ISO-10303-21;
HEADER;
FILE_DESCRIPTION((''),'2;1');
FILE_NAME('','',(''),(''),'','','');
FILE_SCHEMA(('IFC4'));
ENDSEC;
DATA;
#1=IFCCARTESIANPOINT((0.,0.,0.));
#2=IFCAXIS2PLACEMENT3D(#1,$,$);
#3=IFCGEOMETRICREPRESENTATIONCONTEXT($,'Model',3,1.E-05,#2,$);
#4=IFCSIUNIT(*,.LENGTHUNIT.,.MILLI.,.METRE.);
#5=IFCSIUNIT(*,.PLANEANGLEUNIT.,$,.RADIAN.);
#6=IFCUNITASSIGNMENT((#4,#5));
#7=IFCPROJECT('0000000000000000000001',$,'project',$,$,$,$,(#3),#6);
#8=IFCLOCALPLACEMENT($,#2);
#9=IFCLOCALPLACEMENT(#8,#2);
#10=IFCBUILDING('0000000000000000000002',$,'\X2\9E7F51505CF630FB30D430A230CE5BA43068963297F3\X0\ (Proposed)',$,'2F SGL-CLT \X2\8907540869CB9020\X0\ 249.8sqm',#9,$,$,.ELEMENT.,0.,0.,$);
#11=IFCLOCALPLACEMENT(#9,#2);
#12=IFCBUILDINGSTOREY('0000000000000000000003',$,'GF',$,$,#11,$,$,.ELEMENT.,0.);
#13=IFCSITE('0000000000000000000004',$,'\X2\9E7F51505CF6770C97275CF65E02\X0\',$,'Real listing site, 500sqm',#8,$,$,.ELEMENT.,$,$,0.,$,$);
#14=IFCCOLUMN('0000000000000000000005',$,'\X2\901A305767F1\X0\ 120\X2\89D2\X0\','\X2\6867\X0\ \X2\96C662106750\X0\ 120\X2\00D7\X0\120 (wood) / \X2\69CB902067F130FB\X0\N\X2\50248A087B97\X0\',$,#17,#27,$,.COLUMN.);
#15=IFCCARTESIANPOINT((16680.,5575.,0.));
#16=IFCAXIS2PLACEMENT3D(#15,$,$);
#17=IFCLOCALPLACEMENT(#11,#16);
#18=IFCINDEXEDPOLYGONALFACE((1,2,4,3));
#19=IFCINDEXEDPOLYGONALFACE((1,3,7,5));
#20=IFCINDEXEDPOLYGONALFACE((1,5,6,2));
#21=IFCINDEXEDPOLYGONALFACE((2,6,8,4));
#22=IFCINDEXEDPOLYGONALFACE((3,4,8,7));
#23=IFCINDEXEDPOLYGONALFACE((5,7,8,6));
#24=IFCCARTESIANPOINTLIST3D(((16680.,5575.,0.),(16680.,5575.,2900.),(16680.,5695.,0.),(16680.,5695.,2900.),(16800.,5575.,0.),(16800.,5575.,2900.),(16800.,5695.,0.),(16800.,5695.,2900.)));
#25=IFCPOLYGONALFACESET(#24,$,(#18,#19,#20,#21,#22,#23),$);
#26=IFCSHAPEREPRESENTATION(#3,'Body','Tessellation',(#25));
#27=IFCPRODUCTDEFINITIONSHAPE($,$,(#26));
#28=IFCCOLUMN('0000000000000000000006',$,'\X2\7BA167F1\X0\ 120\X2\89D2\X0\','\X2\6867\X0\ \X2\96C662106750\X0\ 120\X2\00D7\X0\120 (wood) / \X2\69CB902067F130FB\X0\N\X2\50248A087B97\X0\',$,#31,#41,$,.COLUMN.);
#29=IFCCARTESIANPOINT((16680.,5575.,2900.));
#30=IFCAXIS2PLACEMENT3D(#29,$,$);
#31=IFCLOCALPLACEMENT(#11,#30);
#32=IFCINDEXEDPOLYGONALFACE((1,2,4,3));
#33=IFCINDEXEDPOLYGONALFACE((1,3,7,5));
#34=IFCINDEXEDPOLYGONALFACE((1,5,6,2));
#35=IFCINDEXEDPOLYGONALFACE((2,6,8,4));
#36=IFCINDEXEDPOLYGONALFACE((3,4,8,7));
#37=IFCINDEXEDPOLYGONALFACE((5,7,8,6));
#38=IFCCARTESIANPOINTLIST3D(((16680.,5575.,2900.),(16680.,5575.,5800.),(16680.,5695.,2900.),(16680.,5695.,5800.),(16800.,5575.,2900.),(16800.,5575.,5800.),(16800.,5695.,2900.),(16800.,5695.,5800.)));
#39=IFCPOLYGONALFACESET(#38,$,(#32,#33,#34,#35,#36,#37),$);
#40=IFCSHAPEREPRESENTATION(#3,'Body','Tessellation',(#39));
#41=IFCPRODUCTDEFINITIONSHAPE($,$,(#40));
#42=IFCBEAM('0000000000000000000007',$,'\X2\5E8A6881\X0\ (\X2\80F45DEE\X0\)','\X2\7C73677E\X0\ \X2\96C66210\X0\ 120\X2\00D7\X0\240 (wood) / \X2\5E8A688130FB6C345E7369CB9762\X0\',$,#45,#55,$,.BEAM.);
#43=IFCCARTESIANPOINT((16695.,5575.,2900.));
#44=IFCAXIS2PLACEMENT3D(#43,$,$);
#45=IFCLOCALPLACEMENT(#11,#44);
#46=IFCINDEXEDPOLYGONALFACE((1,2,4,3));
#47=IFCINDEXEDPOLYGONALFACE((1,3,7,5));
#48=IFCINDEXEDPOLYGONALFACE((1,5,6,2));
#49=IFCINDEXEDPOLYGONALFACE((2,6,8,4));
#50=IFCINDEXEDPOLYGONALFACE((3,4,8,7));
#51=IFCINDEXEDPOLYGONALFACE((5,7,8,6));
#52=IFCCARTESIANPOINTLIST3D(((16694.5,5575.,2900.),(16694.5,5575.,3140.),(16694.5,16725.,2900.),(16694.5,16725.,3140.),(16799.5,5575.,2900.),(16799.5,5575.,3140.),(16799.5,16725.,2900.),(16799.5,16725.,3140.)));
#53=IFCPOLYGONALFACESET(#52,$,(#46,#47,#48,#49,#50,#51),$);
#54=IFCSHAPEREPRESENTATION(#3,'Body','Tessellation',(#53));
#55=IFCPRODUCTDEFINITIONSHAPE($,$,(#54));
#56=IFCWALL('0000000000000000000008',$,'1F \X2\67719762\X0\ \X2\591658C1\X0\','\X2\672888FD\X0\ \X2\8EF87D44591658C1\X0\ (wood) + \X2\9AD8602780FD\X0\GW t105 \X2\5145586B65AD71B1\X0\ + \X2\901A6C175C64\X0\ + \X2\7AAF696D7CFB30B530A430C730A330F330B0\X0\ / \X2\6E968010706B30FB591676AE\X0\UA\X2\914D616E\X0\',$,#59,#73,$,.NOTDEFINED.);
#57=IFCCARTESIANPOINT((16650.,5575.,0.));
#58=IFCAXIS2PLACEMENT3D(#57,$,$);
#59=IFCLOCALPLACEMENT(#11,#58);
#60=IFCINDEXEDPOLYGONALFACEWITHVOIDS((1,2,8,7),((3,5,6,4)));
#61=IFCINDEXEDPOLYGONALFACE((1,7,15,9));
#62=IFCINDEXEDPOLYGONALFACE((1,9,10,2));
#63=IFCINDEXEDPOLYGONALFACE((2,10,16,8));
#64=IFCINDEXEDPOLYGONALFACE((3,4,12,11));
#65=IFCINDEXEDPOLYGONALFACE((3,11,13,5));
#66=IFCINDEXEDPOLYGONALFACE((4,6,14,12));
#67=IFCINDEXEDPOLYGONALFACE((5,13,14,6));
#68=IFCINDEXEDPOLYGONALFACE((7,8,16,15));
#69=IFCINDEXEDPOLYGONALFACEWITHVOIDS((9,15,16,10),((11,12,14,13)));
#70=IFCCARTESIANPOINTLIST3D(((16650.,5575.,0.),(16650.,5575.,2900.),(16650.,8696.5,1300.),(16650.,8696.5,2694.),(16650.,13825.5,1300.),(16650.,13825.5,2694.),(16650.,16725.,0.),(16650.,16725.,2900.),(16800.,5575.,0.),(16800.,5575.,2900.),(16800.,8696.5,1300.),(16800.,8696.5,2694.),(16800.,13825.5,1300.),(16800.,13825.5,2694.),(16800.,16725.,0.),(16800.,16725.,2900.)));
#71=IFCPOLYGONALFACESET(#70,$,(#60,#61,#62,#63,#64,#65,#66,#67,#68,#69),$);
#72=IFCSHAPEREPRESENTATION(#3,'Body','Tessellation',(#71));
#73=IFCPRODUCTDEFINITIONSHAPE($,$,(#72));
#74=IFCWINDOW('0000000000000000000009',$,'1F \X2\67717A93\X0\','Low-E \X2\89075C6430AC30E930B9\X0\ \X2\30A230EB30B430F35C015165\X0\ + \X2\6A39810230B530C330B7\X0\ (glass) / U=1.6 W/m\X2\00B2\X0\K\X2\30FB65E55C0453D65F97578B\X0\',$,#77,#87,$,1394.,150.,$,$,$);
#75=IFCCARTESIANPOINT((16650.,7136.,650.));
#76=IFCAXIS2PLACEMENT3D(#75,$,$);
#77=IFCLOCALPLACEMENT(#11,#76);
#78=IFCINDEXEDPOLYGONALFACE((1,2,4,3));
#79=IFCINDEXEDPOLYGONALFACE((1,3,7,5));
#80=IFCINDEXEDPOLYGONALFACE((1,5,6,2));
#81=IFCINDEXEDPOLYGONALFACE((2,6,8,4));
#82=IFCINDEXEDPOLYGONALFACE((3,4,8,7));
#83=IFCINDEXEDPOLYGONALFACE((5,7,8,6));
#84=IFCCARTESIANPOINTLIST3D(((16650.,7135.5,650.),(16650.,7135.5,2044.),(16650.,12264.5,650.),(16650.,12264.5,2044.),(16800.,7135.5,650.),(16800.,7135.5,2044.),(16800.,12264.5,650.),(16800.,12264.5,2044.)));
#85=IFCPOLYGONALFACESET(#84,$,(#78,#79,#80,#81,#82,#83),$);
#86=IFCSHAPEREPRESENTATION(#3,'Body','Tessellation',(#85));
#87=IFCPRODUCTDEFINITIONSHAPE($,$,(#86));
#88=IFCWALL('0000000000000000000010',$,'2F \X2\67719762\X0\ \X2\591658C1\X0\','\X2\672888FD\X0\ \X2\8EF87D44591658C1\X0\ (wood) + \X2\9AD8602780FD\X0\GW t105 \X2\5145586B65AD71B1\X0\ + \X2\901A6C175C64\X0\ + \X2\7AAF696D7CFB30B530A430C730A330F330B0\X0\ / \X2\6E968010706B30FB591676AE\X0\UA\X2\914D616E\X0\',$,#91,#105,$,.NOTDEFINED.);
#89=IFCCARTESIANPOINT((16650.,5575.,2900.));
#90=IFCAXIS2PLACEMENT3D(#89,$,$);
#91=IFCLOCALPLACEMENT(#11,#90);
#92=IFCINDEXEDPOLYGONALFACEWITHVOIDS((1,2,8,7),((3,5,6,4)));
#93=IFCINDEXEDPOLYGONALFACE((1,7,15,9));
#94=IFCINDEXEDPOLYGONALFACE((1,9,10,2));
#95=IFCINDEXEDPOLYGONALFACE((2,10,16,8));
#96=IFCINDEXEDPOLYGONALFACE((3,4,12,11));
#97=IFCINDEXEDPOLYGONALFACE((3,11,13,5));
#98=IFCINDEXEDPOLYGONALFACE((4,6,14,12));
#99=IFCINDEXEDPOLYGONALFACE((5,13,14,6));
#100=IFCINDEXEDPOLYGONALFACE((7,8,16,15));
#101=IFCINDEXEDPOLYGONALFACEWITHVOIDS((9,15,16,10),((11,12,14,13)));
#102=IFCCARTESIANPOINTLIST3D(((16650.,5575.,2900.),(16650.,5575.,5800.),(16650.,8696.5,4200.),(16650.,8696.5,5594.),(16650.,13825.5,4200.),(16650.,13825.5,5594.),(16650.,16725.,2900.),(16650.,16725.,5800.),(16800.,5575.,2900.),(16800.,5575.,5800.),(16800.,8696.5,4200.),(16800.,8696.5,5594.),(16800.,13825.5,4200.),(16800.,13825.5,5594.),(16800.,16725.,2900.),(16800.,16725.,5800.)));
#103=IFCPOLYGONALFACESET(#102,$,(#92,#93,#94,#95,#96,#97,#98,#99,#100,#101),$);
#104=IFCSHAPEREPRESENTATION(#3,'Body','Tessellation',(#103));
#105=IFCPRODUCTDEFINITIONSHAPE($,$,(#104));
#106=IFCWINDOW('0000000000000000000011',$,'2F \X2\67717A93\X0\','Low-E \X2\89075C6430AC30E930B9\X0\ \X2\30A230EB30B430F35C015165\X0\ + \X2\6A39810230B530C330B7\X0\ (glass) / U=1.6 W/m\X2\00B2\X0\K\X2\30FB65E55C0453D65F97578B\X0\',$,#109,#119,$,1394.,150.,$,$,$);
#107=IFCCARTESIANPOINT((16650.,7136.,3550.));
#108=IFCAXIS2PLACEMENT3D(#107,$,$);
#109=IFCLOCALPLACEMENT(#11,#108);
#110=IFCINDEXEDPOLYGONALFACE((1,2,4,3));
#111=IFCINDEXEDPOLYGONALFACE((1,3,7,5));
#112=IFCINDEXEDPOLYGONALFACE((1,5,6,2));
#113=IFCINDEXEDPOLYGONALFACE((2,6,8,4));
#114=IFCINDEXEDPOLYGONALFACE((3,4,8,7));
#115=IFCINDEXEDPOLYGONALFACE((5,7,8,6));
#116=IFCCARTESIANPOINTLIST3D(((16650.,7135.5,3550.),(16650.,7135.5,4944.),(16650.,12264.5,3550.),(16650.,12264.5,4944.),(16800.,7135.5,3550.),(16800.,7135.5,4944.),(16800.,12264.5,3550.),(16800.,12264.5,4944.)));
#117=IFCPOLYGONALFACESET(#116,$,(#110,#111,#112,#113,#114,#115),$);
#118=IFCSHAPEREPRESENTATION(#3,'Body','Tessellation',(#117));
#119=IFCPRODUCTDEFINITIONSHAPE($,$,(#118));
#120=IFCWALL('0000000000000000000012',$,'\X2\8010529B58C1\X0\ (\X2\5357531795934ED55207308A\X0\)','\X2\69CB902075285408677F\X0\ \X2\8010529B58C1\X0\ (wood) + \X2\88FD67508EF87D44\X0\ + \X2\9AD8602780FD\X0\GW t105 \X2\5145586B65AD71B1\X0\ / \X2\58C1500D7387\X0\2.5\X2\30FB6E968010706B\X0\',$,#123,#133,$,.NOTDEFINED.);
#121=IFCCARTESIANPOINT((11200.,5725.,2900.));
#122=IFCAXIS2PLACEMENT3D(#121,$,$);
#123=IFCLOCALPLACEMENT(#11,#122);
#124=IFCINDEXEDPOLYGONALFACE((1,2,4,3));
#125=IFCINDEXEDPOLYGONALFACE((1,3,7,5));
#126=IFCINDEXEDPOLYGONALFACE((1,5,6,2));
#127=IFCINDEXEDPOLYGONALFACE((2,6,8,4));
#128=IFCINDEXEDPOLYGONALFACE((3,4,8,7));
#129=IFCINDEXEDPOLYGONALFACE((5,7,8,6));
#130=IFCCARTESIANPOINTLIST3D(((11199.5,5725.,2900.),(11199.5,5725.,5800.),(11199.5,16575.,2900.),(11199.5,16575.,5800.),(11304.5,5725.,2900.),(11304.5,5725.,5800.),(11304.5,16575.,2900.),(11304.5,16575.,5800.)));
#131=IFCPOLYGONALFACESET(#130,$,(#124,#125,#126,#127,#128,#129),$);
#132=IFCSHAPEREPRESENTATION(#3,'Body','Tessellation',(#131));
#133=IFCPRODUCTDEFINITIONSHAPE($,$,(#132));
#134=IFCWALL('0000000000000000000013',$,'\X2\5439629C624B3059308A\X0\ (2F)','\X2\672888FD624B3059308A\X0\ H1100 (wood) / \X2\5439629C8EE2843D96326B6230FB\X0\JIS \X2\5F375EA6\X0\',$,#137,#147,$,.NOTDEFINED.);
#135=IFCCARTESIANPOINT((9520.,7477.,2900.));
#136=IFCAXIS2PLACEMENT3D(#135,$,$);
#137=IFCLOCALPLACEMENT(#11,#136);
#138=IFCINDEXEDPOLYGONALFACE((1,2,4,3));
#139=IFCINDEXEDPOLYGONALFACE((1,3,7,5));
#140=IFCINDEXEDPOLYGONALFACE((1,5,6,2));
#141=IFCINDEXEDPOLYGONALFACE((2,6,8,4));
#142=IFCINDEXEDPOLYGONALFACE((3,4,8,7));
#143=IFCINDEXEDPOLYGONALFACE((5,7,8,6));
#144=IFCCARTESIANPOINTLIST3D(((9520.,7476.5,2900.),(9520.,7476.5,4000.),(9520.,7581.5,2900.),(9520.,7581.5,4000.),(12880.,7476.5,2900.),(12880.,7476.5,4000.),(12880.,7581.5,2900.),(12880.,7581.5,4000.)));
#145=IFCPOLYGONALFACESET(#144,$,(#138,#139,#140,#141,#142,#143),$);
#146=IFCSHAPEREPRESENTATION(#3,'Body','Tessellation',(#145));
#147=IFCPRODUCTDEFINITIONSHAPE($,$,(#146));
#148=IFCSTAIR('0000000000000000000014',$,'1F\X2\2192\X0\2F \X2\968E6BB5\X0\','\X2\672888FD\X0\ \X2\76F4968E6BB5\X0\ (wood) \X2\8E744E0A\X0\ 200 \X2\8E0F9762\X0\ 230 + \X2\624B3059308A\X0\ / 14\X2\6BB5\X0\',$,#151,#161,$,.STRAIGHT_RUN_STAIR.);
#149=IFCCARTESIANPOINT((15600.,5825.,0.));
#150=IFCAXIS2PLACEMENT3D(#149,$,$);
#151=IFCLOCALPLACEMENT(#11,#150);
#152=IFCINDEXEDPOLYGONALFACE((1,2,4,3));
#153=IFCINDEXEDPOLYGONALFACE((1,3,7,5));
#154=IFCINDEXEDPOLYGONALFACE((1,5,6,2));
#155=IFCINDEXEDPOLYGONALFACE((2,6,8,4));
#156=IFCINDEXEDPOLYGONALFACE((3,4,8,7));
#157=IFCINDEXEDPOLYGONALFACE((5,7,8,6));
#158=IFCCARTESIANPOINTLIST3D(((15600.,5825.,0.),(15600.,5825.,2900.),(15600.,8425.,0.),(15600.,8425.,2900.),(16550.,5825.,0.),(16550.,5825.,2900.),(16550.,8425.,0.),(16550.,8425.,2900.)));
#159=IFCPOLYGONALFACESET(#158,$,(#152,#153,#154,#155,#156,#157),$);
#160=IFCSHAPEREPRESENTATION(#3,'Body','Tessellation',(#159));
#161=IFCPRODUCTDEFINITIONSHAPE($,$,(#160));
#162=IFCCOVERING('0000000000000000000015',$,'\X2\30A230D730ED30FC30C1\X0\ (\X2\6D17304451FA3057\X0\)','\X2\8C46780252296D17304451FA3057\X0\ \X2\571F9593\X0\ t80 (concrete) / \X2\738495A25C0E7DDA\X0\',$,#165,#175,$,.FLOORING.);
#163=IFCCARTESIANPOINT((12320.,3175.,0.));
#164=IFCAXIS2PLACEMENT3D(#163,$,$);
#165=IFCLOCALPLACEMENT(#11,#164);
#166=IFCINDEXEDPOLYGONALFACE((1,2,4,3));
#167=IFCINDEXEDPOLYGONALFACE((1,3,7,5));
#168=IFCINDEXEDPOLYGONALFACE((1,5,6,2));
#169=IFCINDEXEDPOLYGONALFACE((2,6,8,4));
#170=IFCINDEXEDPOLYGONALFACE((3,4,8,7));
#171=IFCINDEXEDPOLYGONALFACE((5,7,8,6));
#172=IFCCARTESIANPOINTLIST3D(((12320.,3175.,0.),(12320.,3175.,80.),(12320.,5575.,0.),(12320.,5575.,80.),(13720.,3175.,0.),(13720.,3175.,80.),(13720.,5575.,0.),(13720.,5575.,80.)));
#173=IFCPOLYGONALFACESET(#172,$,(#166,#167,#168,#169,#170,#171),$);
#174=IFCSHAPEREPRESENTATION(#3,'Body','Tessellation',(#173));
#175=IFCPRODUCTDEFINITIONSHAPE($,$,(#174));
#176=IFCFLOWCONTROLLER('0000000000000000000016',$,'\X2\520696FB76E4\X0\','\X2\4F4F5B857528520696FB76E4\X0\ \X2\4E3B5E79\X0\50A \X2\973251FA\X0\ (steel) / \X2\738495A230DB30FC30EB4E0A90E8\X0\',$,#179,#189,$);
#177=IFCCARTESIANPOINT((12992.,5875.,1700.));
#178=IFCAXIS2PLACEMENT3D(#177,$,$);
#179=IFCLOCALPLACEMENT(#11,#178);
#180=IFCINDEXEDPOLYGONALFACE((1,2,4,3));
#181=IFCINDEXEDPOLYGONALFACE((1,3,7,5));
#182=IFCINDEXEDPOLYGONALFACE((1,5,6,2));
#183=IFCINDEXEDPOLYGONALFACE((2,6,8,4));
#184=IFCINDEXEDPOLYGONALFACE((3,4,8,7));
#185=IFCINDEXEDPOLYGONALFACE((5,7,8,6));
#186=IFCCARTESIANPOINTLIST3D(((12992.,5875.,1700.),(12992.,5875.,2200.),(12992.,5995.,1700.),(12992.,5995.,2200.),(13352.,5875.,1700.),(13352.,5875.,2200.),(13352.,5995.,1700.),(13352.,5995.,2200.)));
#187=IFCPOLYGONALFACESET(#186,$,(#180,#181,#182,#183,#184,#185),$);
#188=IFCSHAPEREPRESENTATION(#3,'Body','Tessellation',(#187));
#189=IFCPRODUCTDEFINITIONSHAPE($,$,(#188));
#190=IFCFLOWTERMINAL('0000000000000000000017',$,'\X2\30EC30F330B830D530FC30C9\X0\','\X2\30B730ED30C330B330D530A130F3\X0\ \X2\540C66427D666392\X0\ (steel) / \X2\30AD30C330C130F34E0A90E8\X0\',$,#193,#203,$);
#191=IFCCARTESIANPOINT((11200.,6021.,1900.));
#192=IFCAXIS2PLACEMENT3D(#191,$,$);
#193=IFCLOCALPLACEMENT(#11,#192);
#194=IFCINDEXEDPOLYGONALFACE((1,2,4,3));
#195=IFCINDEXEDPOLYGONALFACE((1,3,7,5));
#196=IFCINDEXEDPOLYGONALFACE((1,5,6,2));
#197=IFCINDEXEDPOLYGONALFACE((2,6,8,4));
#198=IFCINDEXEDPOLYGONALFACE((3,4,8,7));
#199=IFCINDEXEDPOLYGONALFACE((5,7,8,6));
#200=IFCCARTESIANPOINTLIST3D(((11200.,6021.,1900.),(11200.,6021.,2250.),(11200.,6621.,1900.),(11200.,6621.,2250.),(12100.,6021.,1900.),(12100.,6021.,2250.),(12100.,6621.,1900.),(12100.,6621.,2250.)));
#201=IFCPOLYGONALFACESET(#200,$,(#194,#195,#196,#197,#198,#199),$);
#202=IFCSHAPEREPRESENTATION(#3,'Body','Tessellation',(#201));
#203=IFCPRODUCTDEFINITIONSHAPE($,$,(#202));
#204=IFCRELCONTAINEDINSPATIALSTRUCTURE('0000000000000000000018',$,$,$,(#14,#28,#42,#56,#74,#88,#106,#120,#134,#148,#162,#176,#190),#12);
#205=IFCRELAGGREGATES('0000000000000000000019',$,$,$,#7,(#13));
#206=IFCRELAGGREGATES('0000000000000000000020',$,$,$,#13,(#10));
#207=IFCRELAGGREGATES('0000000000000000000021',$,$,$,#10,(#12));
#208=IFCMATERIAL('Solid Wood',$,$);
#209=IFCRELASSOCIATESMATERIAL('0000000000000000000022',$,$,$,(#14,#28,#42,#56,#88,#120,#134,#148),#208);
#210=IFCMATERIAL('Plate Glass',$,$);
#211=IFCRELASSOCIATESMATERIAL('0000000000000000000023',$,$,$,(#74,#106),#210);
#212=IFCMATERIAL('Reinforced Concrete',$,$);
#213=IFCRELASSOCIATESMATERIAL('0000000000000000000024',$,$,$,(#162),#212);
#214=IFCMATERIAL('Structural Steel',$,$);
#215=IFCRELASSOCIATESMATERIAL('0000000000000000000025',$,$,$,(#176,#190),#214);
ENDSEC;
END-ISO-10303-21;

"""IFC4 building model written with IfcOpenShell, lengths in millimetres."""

from ifc_helpers import new_model, si_unit, frame, frame_2d, origin, place, context, project, spatial, rectangle, extrude, material, element, fill, save


model = new_model("IFC4")

# Units and contexts
model_context = context("Model", 3, precision=1e-05, world=origin())
ifc_project = project(units=[si_unit("LENGTHUNIT", "METRE", prefix="MILLI"), si_unit("PLANEANGLEUNIT", "RADIAN")], contexts=[model_context])

# Site, building, storey
site_placement = place(None, origin())
site = spatial("IfcSite", under=ifc_project, at=site_placement, Name="鹿児島県霧島市", ObjectType="Real listing site, 500sqm", CompositionType="ELEMENT", RefElevation=0.0)
building_placement = place(site_placement, origin())
building = spatial("IfcBuilding", under=site, at=building_placement, Name="鹿児島・ピアノ室と防音 (Proposed)", ObjectType="2F SGL-CLT 複合構造 249.8sqm", CompositionType="ELEMENT", ElevationOfRefHeight=0.0, ElevationOfTerrain=0.0)
storey_placement = place(building_placement, origin())
storey = spatial("IfcBuildingStorey", under=building, at=storey_placement, Name="GF", CompositionType="ELEMENT", Elevation=0.0)

# Columns
ifc_material_1 = material(Name="Solid Wood")
column_1_placement = place(storey_placement, frame((16680.0, 5575.0, 0.0)))
element("IfcColumn", 1, at=column_1_placement, inside=storey, material=ifc_material_1, Name="通し柱 120角", Description="桧 集成材 120×120 (wood) / 構造柱・N値計算", PredefinedType="COLUMN", context=model_context, shape_type="SweptSolid", body=[
    extrude(rectangle(XDim=120.0, YDim=120.0, at=frame_2d((60.0, 60.0))), frame((16680.0, 5575.0, 0.0)), (0.0, 0.0, 1.0), 2900.0),
])
column_2_placement = place(storey_placement, frame((16680.0, 5575.0, 2900.0)))
element("IfcColumn", 2, at=column_2_placement, inside=storey, material=ifc_material_1, Name="管柱 120角", Description="桧 集成材 120×120 (wood) / 構造柱・N値計算", PredefinedType="COLUMN", context=model_context, shape_type="SweptSolid", body=[
    extrude(rectangle(XDim=120.0, YDim=120.0, at=frame_2d((60.0, 60.0))), frame((16680.0, 5575.0, 2900.0)), (0.0, 0.0, 1.0), 2900.0),
])

# Beam
beam_1_placement = place(storey_placement, frame((16695.0, 5575.0, 2900.0)))
element("IfcBeam", 3, at=beam_1_placement, inside=storey, material=ifc_material_1, Name="床梁 (胴差)", Description="米松 集成 120×240 (wood) / 床梁・水平構面", PredefinedType="BEAM", context=model_context, shape_type="SweptSolid", body=[
    extrude(rectangle(XDim=105.0, YDim=11150.0, at=frame_2d((52.0, 5575.0))), frame((16695.0, 5575.0, 2900.0)), (0.0, 0.0, 1.0), 240.0),
])

# Wall, opening, window
wall_1_placement = place(storey_placement, frame((16650.0, 5575.0, 0.0)))
wall_1 = element("IfcWall", 4, at=wall_1_placement, inside=storey, material=ifc_material_1, Name="1F 東面 外壁", Description="木製 軸組外壁 (wood) + 高性能GW t105 充填断熱 + 通気層 + 窯業系サイディング / 準耐火・外皮UA配慮", PredefinedType="NOTDEFINED", context=model_context, shape_type="SweptSolid", body=[
    extrude(rectangle(XDim=150.0, YDim=11150.0, at=frame_2d((75.0, 5575.0))), frame((16650.0, 5575.0, 0.0)), (0.0, 0.0, 1.0), 2900.0),
])
opening_1_placement = place(storey_placement, frame((16650.0, 7136.0, 650.0)))
opening_1 = element("IfcOpeningElement", 5, at=opening_1_placement, cuts=wall_1, PredefinedType="NOTDEFINED", context=model_context, shape_type="SweptSolid", body=[
    extrude(rectangle(XDim=150.0, YDim=5129.0, at=frame_2d((75.0, 2564.0))), frame((16650.0, 7136.0, 650.0)), (0.0, 0.0, 1.0), 1394.0),
])
ifc_material_2 = material(Name="Plate Glass")
window_1_placement = place(storey_placement, frame((16650.0, 7136.0, 650.0)))
window_1 = element("IfcWindow", 6, at=window_1_placement, inside=storey, material=ifc_material_2, Name="1F 東窓", Description="Low-E 複層ガラス アルゴン封入 + 樹脂サッシ (glass) / U=1.6 W/m²K・日射取得型", OverallHeight=1394.0, OverallWidth=150.0, context=model_context, shape_type="SweptSolid", body=[
    extrude(rectangle(XDim=150.0, YDim=5129.0, at=frame_2d((75.0, 2564.0))), frame((16650.0, 7136.0, 650.0)), (0.0, 0.0, 1.0), 1394.0),
])
fill(opening_1, window_1)

# Wall, opening, window
wall_2_placement = place(storey_placement, frame((16650.0, 5575.0, 2900.0)))
wall_2 = element("IfcWall", 7, at=wall_2_placement, inside=storey, material=ifc_material_1, Name="2F 東面 外壁", Description="木製 軸組外壁 (wood) + 高性能GW t105 充填断熱 + 通気層 + 窯業系サイディング / 準耐火・外皮UA配慮", PredefinedType="NOTDEFINED", context=model_context, shape_type="SweptSolid", body=[
    extrude(rectangle(XDim=150.0, YDim=11150.0, at=frame_2d((75.0, 5575.0))), frame((16650.0, 5575.0, 2900.0)), (0.0, 0.0, 1.0), 2900.0),
])
opening_2_placement = place(storey_placement, frame((16650.0, 7136.0, 3550.0)))
opening_2 = element("IfcOpeningElement", 8, at=opening_2_placement, cuts=wall_2, PredefinedType="NOTDEFINED", context=model_context, shape_type="SweptSolid", body=[
    extrude(rectangle(XDim=150.0, YDim=5129.0, at=frame_2d((75.0, 2564.0))), frame((16650.0, 7136.0, 3550.0)), (0.0, 0.0, 1.0), 1394.0),
])
window_2_placement = place(storey_placement, frame((16650.0, 7136.0, 3550.0)))
window_2 = element("IfcWindow", 9, at=window_2_placement, inside=storey, material=ifc_material_2, Name="2F 東窓", Description="Low-E 複層ガラス アルゴン封入 + 樹脂サッシ (glass) / U=1.6 W/m²K・日射取得型", OverallHeight=1394.0, OverallWidth=150.0, context=model_context, shape_type="SweptSolid", body=[
    extrude(rectangle(XDim=150.0, YDim=5129.0, at=frame_2d((75.0, 2564.0))), frame((16650.0, 7136.0, 3550.0)), (0.0, 0.0, 1.0), 1394.0),
])
fill(opening_2, window_2)

# Walls
wall_3_placement = place(storey_placement, frame((11200.0, 5725.0, 2900.0)))
element("IfcWall", 10, at=wall_3_placement, inside=storey, material=ifc_material_1, Name="耐力壁 (南北間仕切り)", Description="構造用合板 耐力壁 (wood) + 製材軸組 + 高性能GW t105 充填断熱 / 壁倍率2.5・準耐火", PredefinedType="NOTDEFINED", context=model_context, shape_type="SweptSolid", body=[
    extrude(rectangle(XDim=105.0, YDim=10850.0, at=frame_2d((52.0, 5425.0))), frame((11200.0, 5725.0, 2900.0)), (0.0, 0.0, 1.0), 2900.0),
])
wall_4_placement = place(storey_placement, frame((9520.0, 7477.0, 2900.0)))
element("IfcWall", 11, at=wall_4_placement, inside=storey, material=ifc_material_1, Name="吹抜手すり (2F)", Description="木製手すり H1100 (wood) / 吹抜転落防止・JIS 強度", PredefinedType="NOTDEFINED", context=model_context, shape_type="SweptSolid", body=[
    extrude(rectangle(XDim=3360.0, YDim=105.0, at=frame_2d((1680.0, 52.0))), frame((9520.0, 7477.0, 2900.0)), (0.0, 0.0, 1.0), 1100.0),
])

# Stair
stair_placement = place(storey_placement, frame((15600.0, 5825.0, 0.0)))
element("IfcStair", 12, at=stair_placement, inside=storey, material=ifc_material_1, Name="1F→2F 階段", Description="木製 直階段 (wood) 蹴上 200 踏面 230 + 手すり / 14段", PredefinedType="STRAIGHT_RUN_STAIR", context=model_context, shape_type="SweptSolid", body=[
    extrude(rectangle(XDim=950.0, YDim=2600.0, at=frame_2d((475.0, 1300.0))), frame((15600.0, 5825.0, 0.0)), (0.0, 0.0, 1.0), 2900.0),
])

# Covering
ifc_material_3 = material(Name="Reinforced Concrete")
covering_placement = place(storey_placement, frame((12320.0, 3175.0, 0.0)))
element("IfcCovering", 13, at=covering_placement, inside=storey, material=ifc_material_3, Name="アプローチ (洗い出し)", Description="豆砂利洗い出し 土間 t80 (concrete) / 玄関導線", PredefinedType="FLOORING", context=model_context, shape_type="SweptSolid", body=[
    extrude(rectangle(XDim=1400.0, YDim=2400.0, at=frame_2d((700.0, 1200.0))), frame((12320.0, 3175.0, 0.0)), (0.0, 0.0, 1.0), 80.0),
])

# Flow controller
ifc_material_4 = material(Name="Structural Steel")
flow_controller_placement = place(storey_placement, frame((12992.0, 5875.0, 1700.0)))
element("IfcFlowController", 14, at=flow_controller_placement, inside=storey, material=ifc_material_4, Name="分電盤", Description="住宅用分電盤 主幹50A 露出 (steel) / 玄関ホール上部", context=model_context, shape_type="SweptSolid", body=[
    extrude(rectangle(XDim=360.0, YDim=120.0, at=frame_2d((180.0, 60.0))), frame((12992.0, 5875.0, 1700.0)), (0.0, 0.0, 1.0), 500.0),
])

# Flow terminal
flow_terminal_1_placement = place(storey_placement, frame((11200.0, 6021.0, 1900.0)))
element("IfcFlowTerminal", 15, at=flow_terminal_1_placement, inside=storey, material=ifc_material_4, Name="レンジフード", Description="シロッコファン 同時給排 (steel) / キッチン上部", context=model_context, shape_type="SweptSolid", body=[
    extrude(rectangle(XDim=900.0, YDim=600.0, at=frame_2d((450.0, 300.0))), frame((11200.0, 6021.0, 1900.0)), (0.0, 0.0, 1.0), 350.0),
])

save(model, "model.ifc")
